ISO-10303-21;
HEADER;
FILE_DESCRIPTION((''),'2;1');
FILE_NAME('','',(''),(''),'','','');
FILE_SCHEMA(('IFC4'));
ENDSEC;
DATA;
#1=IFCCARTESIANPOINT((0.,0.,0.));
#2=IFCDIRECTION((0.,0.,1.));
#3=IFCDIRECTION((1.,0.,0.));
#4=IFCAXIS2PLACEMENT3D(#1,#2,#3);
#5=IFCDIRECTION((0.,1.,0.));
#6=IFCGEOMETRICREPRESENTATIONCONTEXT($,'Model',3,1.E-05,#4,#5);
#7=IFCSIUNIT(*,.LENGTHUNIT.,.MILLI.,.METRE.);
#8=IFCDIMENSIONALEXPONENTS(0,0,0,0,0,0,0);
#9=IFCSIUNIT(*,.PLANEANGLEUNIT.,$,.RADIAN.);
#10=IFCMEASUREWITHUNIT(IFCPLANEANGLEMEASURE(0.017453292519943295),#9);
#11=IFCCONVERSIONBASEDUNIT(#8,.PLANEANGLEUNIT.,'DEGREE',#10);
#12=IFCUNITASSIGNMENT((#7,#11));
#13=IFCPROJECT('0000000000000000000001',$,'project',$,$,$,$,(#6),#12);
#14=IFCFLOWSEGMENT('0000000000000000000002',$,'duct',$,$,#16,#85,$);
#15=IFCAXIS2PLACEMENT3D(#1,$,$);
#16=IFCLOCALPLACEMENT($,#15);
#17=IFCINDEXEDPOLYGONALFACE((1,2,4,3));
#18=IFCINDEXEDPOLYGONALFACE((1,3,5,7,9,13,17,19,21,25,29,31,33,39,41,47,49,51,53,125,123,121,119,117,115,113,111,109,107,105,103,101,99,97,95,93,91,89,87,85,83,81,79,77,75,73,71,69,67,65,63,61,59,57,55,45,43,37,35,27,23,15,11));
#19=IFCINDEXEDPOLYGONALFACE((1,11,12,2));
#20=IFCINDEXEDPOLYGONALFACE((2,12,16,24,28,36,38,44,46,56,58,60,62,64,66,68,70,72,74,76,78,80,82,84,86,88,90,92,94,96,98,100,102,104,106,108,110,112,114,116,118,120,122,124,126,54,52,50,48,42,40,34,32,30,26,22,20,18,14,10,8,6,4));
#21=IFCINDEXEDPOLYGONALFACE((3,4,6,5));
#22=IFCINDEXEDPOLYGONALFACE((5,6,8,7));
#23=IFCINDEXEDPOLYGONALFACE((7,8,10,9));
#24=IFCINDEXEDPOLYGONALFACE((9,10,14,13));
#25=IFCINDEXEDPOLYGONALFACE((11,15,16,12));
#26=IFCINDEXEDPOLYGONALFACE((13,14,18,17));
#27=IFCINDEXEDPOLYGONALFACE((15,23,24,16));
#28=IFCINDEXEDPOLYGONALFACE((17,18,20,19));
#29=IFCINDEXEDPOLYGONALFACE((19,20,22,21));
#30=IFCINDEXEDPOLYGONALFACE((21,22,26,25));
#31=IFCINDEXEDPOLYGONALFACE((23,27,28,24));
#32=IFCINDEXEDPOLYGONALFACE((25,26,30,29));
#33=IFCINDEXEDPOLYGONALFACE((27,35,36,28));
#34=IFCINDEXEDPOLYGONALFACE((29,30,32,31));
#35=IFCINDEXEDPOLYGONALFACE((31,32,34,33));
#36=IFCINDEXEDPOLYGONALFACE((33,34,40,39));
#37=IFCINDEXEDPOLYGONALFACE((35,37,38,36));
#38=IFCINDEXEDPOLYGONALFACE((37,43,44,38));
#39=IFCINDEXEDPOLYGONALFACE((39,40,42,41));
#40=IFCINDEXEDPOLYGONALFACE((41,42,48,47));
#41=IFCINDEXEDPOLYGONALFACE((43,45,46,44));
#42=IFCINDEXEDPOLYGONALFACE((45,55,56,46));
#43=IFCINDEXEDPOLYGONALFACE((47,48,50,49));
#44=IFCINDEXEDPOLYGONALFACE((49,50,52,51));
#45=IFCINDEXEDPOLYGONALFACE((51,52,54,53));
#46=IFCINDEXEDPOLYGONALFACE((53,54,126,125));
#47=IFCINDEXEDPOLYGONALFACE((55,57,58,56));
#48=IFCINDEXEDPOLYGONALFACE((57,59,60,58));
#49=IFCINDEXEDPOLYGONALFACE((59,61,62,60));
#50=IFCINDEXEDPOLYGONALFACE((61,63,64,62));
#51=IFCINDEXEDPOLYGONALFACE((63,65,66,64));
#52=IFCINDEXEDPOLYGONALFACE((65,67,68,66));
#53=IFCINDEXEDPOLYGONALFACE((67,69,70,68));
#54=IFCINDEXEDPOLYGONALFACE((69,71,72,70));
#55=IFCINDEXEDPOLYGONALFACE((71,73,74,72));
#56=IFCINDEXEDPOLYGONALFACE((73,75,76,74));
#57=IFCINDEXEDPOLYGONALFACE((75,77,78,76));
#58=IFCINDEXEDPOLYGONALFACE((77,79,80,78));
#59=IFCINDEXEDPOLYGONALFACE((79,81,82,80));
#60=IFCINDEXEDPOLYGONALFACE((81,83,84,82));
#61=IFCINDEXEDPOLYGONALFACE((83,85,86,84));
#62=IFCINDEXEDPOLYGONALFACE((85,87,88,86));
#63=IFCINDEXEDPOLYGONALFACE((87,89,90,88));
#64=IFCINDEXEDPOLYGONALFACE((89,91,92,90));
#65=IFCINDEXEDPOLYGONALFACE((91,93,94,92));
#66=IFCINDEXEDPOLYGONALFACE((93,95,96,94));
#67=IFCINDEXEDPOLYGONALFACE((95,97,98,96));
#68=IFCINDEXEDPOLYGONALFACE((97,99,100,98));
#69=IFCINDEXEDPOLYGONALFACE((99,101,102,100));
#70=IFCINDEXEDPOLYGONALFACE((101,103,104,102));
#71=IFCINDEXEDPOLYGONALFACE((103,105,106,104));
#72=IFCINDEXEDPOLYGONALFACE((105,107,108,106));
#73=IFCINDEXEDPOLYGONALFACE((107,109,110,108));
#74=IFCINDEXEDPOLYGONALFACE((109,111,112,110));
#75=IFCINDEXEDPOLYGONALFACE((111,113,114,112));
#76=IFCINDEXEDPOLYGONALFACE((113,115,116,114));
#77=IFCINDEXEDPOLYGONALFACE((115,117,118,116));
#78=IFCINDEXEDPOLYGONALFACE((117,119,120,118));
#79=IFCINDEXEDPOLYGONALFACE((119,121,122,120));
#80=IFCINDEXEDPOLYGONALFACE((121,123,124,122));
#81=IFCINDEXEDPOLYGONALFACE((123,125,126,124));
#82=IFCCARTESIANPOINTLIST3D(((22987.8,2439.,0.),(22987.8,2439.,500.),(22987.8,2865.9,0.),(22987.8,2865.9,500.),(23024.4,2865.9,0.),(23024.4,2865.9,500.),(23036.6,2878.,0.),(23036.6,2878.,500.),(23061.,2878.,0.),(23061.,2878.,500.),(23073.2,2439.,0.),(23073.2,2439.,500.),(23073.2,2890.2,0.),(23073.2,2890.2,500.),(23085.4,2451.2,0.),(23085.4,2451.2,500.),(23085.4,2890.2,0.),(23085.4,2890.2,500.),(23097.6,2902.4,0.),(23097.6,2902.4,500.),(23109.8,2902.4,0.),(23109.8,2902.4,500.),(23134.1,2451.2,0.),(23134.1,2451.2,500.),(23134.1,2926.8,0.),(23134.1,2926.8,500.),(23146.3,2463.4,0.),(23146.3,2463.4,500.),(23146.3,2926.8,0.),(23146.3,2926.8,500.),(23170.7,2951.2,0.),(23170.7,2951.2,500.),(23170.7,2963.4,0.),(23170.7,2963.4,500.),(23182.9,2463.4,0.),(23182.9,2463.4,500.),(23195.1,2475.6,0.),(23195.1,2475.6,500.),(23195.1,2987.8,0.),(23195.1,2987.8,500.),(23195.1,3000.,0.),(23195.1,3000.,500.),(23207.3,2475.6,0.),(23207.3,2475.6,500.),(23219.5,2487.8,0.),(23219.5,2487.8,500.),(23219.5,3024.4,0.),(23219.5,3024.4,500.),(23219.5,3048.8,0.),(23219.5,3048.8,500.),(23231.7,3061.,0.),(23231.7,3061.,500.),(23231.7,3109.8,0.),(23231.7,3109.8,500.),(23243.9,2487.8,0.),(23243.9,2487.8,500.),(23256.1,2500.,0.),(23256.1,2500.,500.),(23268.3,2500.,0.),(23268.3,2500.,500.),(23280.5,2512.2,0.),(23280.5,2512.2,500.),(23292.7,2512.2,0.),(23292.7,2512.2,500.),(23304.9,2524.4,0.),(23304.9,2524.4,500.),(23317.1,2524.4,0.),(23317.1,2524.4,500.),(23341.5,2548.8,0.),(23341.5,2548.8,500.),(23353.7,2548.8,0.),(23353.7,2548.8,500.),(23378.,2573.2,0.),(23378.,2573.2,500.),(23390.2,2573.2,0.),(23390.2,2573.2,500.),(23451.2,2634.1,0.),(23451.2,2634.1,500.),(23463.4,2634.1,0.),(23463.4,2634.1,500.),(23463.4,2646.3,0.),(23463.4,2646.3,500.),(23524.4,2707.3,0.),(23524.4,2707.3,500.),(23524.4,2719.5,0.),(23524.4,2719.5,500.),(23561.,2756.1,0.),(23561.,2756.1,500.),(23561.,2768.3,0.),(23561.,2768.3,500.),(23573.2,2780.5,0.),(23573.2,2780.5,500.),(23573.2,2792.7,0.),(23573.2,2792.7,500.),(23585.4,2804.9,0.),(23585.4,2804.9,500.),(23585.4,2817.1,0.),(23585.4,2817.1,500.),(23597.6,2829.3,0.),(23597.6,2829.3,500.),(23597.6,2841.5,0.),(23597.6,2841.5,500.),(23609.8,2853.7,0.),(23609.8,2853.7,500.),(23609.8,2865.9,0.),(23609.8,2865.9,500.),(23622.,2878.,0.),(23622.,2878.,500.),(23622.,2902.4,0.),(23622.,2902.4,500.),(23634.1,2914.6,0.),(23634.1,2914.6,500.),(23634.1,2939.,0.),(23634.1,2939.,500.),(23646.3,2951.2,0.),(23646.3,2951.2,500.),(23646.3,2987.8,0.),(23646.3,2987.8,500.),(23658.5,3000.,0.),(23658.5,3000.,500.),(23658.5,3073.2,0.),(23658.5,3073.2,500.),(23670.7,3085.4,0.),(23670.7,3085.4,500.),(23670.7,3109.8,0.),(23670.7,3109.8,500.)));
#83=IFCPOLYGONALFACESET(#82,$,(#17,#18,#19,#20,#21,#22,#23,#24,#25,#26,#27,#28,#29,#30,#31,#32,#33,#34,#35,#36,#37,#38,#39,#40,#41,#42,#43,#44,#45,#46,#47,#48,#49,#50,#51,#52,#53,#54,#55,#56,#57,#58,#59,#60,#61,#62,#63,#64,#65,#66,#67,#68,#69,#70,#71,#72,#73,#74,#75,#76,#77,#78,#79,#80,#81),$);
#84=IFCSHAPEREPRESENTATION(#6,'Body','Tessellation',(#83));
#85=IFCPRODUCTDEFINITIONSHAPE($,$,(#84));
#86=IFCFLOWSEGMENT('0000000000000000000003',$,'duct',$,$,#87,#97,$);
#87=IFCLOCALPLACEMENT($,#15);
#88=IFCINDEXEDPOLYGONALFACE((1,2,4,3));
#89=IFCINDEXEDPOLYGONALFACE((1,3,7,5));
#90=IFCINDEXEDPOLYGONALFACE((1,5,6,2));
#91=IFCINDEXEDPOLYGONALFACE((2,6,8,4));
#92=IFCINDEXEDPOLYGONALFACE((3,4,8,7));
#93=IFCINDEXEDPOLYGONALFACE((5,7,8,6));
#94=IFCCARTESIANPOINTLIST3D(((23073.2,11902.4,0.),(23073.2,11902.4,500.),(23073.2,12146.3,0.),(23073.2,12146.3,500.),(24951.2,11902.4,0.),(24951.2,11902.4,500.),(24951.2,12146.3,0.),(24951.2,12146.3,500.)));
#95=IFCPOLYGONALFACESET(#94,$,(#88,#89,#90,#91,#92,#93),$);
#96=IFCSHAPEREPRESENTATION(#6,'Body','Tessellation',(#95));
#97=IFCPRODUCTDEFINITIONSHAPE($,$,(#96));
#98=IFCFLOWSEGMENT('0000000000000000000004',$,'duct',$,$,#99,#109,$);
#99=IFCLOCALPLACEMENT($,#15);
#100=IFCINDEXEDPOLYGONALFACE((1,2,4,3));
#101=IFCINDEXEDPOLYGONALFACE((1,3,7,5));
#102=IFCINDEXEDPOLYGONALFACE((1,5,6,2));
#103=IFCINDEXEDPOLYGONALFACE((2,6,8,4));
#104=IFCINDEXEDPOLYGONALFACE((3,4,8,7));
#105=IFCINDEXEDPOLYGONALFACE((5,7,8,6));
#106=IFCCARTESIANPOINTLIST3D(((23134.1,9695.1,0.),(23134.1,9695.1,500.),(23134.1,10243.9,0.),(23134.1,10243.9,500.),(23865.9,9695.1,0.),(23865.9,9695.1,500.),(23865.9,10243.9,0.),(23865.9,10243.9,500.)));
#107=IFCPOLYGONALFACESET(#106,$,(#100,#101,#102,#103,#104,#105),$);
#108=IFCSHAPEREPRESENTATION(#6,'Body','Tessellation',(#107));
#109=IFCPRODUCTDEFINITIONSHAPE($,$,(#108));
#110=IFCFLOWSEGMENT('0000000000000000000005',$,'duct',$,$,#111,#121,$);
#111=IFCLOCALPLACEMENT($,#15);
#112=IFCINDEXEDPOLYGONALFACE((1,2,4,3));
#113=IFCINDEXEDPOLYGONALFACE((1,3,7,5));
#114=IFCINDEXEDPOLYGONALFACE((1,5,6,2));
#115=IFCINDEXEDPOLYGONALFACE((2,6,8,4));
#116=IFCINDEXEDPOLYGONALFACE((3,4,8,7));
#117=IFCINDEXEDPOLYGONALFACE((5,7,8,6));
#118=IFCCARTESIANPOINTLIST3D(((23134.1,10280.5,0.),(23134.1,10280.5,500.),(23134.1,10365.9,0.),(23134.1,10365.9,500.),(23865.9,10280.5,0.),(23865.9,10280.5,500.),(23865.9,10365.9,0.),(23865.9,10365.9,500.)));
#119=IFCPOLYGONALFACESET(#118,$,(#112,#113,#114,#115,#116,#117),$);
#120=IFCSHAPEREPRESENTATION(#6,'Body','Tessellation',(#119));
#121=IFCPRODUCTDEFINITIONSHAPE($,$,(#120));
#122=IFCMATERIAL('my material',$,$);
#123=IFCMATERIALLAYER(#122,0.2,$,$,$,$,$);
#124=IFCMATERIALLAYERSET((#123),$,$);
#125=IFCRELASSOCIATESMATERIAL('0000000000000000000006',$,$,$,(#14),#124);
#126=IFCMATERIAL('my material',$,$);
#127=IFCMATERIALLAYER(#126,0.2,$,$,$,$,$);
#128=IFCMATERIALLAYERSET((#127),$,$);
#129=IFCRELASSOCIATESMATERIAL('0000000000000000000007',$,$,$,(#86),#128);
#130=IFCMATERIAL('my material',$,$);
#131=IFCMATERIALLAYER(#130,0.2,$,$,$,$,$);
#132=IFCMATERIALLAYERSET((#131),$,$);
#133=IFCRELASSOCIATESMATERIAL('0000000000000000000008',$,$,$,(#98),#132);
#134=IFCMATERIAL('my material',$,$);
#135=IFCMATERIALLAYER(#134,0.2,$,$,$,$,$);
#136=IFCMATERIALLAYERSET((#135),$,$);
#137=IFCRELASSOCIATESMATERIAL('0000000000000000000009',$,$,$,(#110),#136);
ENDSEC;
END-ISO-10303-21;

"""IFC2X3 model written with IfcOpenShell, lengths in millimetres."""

from ifc_helpers import new_model, entity, si_unit, converted_unit, direction, origin_with_axes, place, context, project, polyline, outline, extrude, material, layer, layer_set, layer_usage, element, save


model = new_model("IFC2X3")

# Units and contexts
model_context = context("Model", 3, precision=1e-05, world=origin_with_axes(), true_north=direction((0.0, 1.0, 0.0)))
ifc_project = project(units=[si_unit("LENGTHUNIT", "METRE", prefix="MILLI"), converted_unit("PLANEANGLEUNIT", "DEGREE", entity("IfcPlaneAngleMeasure", 0.017453292519943295), si_unit("PLANEANGLEUNIT", "RADIAN"), dimensions=[0, 0, 0, 0, 0, 0, 0])], contexts=[model_context])

# Flow segments
ifc_material_1 = material(Name="my material")
ifc_layer_1 = layer(ifc_material_1, 0.2)
ifc_layer_set_1 = layer_set([ifc_layer_1])
ifc_layer_usage_1 = layer_usage(ifc_layer_set_1, "AXIS2", "POSITIVE", -0.1)
flow_segment_1_placement = place(None, origin_with_axes())
element("IfcFlowSegment", 1, at=flow_segment_1_placement, material=ifc_layer_usage_1, Name="duct", context=model_context, shape_type="SweptSolid", body=[
    extrude(outline(polyline([(22987.8, 2439.0), (23073.2, 2439.0), (23085.4, 2451.2), (23134.1, 2451.2), (23146.3, 2463.4), (23182.9, 2463.4), (23195.1, 2475.6), (23207.3, 2475.6), (23219.5, 2487.8), (23243.9, 2487.8), (23256.1, 2500.0), (23268.3, 2500.0), (23280.5, 2512.2), (23292.7, 2512.2), (23304.9, 2524.4), (23317.1, 2524.4), (23341.5, 2548.8), (23353.7, 2548.8), (23378.0, 2573.2), (23390.2, 2573.2), (23451.2, 2634.1), (23463.4, 2634.1), (23463.4, 2646.3), (23524.4, 2707.3), (23524.4, 2719.5), (23561.0, 2756.1), (23561.0, 2768.3), (23573.2, 2780.5), (23573.2, 2792.7), (23585.4, 2804.9), (23585.4, 2817.1), (23597.6, 2829.3), (23597.6, 2841.5), (23609.8, 2853.7), (23609.8, 2865.9), (23622.0, 2878.0), (23622.0, 2902.4), (23634.1, 2914.6), (23634.1, 2939.0), (23646.3, 2951.2), (23646.3, 2987.8), (23658.5, 3000.0), (23658.5, 3073.2), (23670.7, 3085.4), (23670.7, 3109.8), (23231.7, 3109.8), (23231.7, 3061.0), (23219.5, 3048.8), (23219.5, 3024.4), (23195.1, 3000.0), (23195.1, 2987.8), (23170.7, 2963.4), (23170.7, 2951.2), (23146.3, 2926.8), (23134.1, 2926.8), (23109.8, 2902.4), (23097.6, 2902.4), (23085.4, 2890.2), (23073.2, 2890.2), (23061.0, 2878.0), (23036.6, 2878.0), (23024.4, 2865.9), (22987.8, 2865.9), (22987.8, 2439.0)])), origin_with_axes(), (0.0, 0.0, 1.0), 500.0),
])
ifc_material_2 = material(Name="my material")
ifc_layer_2 = layer(ifc_material_2, 0.2)
ifc_layer_set_2 = layer_set([ifc_layer_2])
ifc_layer_usage_2 = layer_usage(ifc_layer_set_2, "AXIS2", "POSITIVE", -0.1)
flow_segment_2_placement = place(None, origin_with_axes())
element("IfcFlowSegment", 2, at=flow_segment_2_placement, material=ifc_layer_usage_2, Name="duct", context=model_context, shape_type="SweptSolid", body=[
    extrude(outline(polyline([(23073.2, 11902.4), (24951.2, 11902.4), (24951.2, 12146.3), (23073.2, 12146.3), (23073.2, 11902.4)])), origin_with_axes(), (0.0, 0.0, 1.0), 500.0),
])
ifc_material_3 = material(Name="my material")
ifc_layer_3 = layer(ifc_material_3, 0.2)
ifc_layer_set_3 = layer_set([ifc_layer_3])
ifc_layer_usage_3 = layer_usage(ifc_layer_set_3, "AXIS2", "POSITIVE", -0.1)
flow_segment_3_placement = place(None, origin_with_axes())
element("IfcFlowSegment", 3, at=flow_segment_3_placement, material=ifc_layer_usage_3, Name="duct", context=model_context, shape_type="SweptSolid", body=[
    extrude(outline(polyline([(23134.1, 9695.1), (23865.9, 9695.1), (23865.9, 10243.9), (23134.1, 10243.9), (23134.1, 9695.1)])), origin_with_axes(), (0.0, 0.0, 1.0), 500.0),
])
ifc_material_4 = material(Name="my material")
ifc_layer_4 = layer(ifc_material_4, 0.2)
ifc_layer_set_4 = layer_set([ifc_layer_4])
ifc_layer_usage_4 = layer_usage(ifc_layer_set_4, "AXIS2", "POSITIVE", -0.1)
flow_segment_4_placement = place(None, origin_with_axes())
element("IfcFlowSegment", 4, at=flow_segment_4_placement, material=ifc_layer_usage_4, Name="duct", context=model_context, shape_type="SweptSolid", body=[
    extrude(outline(polyline([(23134.1, 10280.5), (23865.9, 10280.5), (23865.9, 10365.9), (23134.1, 10365.9), (23134.1, 10280.5)])), origin_with_axes(), (0.0, 0.0, 1.0), 500.0),
])

save(model, "model.ifc")
